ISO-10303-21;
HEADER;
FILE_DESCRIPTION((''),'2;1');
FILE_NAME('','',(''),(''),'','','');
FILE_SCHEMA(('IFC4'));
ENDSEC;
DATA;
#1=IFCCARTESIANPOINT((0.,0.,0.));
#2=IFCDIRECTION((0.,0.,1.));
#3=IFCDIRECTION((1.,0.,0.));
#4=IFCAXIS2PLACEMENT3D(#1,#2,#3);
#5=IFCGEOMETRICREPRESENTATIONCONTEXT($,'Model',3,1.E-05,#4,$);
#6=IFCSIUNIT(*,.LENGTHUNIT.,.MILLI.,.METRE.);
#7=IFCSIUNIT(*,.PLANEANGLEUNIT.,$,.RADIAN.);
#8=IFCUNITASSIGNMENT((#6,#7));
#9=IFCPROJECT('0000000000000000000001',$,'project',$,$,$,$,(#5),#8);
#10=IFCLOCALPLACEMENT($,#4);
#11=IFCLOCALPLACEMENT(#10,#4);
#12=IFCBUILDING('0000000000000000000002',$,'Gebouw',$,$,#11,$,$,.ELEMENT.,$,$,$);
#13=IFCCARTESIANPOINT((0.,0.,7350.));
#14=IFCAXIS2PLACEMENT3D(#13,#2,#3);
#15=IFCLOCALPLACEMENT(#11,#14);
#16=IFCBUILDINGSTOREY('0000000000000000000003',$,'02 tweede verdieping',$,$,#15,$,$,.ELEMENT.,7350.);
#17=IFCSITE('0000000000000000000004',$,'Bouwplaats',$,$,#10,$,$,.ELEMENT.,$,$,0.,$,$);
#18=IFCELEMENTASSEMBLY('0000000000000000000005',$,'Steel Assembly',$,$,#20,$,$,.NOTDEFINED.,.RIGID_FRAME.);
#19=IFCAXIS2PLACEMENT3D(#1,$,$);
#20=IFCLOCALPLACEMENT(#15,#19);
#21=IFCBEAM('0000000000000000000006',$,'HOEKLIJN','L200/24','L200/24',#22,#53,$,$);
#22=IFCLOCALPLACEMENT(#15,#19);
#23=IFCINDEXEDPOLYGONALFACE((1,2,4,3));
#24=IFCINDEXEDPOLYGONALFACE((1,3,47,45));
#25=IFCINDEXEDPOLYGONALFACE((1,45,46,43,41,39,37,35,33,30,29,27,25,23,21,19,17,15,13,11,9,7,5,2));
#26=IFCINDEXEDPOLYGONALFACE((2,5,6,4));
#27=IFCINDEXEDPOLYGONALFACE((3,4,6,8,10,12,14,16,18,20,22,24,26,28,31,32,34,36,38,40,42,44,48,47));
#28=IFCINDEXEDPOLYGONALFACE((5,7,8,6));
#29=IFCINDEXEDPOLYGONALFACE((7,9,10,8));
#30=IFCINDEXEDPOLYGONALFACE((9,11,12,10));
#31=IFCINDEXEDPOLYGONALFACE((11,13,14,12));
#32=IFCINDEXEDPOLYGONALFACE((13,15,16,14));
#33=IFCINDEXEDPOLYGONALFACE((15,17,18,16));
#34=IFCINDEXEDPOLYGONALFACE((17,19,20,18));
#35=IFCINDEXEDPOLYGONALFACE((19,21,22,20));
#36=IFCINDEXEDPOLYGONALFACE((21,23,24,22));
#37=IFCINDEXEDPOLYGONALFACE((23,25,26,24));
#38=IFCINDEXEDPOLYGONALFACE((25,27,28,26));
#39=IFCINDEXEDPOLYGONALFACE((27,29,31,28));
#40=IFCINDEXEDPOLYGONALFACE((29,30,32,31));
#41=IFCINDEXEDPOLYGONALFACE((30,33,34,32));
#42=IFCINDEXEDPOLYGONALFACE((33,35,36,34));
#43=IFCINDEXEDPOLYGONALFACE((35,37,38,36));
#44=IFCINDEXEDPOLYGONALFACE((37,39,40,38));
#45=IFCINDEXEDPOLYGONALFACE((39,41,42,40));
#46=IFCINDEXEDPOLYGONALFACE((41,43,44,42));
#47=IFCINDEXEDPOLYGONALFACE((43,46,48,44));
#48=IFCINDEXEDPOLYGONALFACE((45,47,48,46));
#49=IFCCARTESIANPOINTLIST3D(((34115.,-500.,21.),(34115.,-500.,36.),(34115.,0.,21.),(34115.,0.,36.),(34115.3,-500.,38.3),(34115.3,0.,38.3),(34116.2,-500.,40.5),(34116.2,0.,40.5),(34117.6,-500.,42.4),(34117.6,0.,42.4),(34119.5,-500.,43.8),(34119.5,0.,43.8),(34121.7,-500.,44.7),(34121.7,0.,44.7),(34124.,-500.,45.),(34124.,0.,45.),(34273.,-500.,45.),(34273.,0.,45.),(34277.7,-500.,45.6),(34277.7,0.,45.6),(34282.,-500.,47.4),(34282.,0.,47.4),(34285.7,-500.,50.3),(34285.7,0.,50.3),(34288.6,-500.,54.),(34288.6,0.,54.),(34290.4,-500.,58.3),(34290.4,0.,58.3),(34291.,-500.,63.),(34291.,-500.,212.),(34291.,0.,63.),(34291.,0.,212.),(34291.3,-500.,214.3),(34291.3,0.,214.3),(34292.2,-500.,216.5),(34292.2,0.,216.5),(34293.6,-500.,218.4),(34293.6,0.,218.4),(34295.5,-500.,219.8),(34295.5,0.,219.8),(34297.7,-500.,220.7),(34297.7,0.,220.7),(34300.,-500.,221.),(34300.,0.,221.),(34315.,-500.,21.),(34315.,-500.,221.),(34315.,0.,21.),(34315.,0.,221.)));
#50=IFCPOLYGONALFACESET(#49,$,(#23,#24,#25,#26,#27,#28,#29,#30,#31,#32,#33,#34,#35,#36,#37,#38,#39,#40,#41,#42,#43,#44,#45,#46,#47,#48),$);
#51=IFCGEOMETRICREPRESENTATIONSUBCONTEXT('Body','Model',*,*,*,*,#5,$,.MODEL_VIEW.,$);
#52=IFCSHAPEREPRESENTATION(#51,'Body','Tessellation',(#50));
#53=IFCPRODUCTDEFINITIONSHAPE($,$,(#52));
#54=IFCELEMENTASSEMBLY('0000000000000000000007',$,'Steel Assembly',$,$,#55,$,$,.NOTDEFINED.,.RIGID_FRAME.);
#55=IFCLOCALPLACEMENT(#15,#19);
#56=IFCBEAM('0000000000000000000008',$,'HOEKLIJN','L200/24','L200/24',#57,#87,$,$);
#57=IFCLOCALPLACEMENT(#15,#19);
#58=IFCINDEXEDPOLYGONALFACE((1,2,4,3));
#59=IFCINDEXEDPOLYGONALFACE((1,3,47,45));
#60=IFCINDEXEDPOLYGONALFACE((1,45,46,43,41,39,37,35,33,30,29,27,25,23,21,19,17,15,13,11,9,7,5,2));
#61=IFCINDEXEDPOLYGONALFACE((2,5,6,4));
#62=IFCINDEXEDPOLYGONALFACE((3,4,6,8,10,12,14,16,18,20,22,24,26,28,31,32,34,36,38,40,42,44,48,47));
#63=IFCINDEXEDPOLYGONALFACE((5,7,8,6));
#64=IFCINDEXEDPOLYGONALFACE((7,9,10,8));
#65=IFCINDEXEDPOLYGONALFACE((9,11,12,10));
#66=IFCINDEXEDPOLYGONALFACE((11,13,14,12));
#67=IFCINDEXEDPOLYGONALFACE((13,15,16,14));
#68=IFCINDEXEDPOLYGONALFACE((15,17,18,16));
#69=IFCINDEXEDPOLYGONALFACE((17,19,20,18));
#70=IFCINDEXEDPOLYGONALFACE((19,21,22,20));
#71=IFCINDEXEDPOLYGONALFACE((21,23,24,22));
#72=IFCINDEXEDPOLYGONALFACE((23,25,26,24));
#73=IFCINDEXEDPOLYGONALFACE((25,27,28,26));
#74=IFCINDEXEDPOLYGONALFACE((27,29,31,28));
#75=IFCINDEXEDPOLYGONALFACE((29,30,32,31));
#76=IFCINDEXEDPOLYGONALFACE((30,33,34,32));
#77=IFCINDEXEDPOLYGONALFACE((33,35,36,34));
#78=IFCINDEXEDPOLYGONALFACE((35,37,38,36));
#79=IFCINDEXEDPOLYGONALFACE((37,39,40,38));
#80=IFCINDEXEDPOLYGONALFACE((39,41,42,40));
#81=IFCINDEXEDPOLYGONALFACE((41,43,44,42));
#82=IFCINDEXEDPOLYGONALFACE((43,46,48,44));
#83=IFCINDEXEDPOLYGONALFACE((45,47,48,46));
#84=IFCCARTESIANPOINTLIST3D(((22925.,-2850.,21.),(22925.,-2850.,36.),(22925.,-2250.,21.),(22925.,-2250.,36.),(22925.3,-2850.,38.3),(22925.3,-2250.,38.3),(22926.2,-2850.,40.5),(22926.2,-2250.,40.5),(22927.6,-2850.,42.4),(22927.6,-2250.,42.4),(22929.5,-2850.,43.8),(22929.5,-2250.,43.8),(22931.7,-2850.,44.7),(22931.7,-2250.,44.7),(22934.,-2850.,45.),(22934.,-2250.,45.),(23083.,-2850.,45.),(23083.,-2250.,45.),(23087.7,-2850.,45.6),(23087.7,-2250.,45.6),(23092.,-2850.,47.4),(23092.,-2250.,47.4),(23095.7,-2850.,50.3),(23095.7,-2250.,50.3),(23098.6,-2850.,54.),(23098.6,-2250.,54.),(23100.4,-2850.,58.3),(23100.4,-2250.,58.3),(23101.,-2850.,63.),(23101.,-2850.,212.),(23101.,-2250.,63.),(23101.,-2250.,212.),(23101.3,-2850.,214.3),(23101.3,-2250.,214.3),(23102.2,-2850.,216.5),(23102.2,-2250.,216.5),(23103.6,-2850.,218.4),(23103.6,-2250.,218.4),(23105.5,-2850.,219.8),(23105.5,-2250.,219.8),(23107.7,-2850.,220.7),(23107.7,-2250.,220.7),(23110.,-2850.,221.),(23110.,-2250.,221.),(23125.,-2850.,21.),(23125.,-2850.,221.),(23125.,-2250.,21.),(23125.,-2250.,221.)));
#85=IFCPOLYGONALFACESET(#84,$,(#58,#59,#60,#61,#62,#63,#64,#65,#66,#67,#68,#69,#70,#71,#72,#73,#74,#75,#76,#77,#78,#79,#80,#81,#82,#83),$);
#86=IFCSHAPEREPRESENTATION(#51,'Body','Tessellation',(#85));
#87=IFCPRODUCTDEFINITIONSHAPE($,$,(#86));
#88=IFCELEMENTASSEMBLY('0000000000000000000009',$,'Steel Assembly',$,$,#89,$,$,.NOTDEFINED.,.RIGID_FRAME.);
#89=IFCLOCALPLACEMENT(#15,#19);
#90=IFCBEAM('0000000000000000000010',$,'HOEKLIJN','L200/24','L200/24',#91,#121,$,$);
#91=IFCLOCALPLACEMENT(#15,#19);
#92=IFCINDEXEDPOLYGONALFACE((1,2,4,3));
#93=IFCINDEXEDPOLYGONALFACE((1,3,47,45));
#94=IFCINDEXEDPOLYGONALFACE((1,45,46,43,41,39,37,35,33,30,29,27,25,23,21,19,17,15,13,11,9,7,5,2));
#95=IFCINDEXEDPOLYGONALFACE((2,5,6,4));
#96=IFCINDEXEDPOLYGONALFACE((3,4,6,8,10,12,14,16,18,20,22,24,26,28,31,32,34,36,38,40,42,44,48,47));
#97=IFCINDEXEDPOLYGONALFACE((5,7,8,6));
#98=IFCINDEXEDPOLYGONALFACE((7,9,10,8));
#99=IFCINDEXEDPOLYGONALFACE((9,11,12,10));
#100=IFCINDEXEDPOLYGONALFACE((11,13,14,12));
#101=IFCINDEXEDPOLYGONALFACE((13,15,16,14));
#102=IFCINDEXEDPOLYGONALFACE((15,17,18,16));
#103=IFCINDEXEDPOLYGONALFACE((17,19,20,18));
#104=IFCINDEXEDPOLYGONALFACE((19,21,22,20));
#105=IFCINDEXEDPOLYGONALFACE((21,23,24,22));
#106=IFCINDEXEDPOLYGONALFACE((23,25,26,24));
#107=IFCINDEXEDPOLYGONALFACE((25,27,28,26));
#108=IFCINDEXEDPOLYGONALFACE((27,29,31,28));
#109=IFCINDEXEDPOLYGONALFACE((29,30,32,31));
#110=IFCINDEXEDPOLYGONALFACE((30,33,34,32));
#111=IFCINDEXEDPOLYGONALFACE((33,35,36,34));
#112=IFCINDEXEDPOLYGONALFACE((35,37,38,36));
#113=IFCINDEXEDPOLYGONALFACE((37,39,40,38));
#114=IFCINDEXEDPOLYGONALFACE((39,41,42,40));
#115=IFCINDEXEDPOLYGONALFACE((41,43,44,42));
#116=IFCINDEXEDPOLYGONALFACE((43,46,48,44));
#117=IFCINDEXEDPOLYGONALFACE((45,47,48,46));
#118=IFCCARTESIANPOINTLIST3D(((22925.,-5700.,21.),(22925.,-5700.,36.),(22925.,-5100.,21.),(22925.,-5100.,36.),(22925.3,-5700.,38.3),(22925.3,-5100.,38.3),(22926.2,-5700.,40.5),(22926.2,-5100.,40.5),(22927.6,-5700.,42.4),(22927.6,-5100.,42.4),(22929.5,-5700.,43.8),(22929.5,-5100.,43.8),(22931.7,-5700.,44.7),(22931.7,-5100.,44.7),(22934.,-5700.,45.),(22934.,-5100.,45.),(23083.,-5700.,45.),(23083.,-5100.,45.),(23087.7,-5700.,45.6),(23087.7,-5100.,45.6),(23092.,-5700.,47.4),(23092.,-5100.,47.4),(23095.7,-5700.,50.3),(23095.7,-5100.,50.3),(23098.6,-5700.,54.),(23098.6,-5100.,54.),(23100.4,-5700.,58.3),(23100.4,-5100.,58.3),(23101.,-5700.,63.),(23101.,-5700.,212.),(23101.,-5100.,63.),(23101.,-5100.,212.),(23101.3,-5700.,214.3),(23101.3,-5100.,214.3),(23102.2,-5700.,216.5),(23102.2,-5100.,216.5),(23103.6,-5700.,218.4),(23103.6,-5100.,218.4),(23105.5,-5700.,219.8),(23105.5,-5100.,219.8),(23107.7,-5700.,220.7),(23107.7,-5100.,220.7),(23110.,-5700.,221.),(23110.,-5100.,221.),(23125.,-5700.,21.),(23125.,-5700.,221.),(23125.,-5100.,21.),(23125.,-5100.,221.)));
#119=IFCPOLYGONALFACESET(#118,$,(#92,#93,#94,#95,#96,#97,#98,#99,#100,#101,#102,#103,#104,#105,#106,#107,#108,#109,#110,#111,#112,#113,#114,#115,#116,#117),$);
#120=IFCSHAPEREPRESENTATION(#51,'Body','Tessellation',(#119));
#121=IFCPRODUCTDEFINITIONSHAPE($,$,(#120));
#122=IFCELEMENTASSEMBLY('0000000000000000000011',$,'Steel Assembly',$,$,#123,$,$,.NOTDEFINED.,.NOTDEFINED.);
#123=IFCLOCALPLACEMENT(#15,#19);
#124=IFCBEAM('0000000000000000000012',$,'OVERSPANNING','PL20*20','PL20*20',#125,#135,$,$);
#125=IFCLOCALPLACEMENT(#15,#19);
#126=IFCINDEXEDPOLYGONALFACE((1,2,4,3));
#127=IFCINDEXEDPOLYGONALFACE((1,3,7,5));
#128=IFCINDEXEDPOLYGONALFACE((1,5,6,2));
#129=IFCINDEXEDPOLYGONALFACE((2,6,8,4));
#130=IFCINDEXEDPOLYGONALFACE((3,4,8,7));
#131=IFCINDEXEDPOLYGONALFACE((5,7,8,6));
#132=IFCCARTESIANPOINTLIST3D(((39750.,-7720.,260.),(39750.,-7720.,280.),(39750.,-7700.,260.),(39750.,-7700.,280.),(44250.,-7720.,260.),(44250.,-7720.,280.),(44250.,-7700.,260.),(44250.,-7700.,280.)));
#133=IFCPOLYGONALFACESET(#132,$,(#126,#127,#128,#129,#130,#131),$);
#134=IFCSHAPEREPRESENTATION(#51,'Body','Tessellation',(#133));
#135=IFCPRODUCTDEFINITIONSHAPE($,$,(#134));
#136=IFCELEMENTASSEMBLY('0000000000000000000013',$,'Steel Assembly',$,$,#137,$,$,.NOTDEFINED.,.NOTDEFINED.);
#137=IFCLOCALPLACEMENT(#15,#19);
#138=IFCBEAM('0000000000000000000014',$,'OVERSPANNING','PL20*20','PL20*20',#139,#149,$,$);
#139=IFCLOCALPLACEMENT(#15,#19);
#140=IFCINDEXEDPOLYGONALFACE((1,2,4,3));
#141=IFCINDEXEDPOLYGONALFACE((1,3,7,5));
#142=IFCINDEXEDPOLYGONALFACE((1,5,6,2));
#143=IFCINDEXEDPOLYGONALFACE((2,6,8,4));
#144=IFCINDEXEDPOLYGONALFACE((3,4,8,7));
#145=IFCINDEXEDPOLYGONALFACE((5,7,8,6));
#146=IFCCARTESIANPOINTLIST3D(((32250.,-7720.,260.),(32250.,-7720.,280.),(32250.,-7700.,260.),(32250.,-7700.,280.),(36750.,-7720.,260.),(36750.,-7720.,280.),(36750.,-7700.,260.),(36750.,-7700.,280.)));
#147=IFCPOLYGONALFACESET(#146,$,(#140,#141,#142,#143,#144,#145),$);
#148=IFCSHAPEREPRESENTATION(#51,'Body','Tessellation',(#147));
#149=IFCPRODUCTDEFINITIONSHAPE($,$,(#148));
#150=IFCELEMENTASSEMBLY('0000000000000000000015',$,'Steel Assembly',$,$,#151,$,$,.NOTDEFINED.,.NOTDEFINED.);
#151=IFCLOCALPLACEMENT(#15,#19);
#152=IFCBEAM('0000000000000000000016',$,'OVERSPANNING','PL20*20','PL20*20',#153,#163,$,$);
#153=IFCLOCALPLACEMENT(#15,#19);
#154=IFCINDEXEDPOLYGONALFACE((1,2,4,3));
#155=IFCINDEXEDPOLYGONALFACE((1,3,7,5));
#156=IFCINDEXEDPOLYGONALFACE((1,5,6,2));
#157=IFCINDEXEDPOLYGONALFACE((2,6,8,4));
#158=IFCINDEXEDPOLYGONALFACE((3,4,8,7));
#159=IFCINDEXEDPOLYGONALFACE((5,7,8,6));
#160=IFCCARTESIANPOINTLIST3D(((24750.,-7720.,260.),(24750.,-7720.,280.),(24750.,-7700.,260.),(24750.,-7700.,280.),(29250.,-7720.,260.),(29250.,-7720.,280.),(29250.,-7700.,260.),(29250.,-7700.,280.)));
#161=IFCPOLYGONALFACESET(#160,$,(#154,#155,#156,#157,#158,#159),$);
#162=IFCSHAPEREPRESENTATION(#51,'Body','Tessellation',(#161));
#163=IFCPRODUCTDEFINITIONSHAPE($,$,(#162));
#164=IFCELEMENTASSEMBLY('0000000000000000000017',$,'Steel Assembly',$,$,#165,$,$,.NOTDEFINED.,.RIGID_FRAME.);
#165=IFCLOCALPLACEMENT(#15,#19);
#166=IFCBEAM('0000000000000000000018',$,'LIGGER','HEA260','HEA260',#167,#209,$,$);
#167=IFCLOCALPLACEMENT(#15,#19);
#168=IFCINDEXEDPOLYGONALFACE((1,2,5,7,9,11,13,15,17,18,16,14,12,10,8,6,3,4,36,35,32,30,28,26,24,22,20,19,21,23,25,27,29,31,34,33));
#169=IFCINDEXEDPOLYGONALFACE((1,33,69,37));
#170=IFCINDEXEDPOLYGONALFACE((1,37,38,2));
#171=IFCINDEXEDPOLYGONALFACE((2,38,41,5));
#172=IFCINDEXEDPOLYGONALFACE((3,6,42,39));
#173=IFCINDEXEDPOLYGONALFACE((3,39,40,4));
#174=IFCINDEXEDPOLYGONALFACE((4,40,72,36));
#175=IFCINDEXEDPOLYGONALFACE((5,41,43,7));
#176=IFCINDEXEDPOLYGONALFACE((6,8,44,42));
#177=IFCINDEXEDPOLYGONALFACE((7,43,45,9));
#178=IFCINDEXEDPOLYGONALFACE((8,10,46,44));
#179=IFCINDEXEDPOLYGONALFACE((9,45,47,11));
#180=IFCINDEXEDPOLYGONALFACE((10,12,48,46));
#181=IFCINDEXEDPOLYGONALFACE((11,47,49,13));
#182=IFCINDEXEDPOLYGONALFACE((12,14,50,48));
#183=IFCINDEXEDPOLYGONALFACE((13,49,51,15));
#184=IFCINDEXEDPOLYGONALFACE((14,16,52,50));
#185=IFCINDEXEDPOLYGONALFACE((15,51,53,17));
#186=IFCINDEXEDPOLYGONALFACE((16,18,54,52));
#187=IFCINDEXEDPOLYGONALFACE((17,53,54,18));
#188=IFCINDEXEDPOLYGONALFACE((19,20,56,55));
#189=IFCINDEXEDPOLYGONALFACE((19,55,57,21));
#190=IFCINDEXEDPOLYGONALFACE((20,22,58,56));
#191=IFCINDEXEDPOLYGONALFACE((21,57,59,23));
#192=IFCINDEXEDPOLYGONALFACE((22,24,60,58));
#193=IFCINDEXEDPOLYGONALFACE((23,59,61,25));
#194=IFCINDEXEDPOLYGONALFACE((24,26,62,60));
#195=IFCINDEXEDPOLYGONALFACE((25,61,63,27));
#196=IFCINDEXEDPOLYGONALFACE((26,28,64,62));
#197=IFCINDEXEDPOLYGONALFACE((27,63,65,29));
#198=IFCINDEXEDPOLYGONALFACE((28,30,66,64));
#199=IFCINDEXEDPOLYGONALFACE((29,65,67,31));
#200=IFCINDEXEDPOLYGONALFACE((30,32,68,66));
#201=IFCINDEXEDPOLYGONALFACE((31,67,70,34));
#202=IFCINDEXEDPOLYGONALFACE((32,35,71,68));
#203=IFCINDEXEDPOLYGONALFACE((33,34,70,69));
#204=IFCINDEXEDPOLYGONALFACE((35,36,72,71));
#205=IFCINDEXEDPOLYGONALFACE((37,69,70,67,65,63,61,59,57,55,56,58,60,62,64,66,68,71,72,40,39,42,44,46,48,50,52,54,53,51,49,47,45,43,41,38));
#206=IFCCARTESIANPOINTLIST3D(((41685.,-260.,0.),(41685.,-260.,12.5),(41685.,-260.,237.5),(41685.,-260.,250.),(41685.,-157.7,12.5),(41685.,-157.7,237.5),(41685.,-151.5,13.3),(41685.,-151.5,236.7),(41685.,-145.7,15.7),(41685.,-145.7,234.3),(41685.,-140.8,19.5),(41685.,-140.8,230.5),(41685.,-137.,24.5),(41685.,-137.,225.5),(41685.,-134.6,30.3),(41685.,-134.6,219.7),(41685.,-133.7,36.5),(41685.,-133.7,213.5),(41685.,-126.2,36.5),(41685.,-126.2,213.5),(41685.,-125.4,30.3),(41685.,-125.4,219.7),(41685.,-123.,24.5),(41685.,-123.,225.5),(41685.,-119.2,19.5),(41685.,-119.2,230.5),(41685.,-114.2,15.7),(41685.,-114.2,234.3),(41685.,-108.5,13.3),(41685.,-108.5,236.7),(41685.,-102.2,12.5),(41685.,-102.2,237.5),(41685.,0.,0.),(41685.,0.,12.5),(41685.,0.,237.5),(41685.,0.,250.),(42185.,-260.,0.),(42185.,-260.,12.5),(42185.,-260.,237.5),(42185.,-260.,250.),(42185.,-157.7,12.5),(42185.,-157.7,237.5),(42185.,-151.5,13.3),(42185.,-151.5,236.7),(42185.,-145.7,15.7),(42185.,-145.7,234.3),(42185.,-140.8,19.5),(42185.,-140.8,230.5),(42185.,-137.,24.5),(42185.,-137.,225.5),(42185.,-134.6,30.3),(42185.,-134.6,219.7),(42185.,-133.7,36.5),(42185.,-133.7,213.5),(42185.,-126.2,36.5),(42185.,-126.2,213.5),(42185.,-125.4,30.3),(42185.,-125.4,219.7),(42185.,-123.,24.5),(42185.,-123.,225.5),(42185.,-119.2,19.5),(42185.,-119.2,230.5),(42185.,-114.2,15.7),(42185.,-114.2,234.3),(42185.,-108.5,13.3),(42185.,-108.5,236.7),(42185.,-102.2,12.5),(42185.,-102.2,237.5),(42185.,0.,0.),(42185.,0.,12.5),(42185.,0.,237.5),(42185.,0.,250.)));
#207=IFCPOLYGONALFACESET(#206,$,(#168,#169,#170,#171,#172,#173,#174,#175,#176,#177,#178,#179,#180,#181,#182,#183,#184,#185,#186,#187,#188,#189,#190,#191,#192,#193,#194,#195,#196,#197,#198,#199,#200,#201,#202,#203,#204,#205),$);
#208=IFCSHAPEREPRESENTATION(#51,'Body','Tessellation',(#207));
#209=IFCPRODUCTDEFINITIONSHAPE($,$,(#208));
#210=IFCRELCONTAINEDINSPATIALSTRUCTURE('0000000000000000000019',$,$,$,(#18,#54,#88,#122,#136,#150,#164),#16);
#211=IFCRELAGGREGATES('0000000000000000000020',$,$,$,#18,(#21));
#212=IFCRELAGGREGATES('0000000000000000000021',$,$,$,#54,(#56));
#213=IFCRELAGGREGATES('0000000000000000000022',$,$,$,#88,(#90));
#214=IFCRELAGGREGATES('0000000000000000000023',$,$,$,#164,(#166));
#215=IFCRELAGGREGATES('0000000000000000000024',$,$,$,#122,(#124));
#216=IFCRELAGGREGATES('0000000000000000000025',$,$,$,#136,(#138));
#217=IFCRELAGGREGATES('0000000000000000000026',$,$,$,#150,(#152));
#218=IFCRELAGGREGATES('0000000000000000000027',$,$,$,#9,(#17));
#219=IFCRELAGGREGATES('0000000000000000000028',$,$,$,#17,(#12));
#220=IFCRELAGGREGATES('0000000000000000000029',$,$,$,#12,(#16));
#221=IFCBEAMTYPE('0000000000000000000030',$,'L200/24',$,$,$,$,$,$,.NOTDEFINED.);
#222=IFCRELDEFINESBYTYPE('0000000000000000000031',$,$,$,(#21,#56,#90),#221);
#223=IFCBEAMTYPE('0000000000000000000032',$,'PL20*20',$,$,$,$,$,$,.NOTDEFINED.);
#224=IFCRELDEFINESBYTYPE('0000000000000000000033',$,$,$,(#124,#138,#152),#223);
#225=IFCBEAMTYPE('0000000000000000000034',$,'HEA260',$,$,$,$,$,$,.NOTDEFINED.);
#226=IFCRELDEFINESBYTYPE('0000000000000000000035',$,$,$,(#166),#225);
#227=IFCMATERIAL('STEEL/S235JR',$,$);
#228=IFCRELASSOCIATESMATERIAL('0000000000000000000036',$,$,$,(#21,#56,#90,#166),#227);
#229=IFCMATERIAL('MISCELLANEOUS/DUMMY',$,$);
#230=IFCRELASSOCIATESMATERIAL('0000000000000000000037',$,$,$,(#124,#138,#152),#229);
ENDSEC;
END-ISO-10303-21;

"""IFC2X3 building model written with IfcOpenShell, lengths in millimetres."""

from ifc_helpers import new_model, si_unit, frame, origin_with_axes, origin_2d_with_axis, place, context, subcontext, project, spatial, rectangle, i_section, l_section, extrude, material, type_object, element, aggregate, save


model = new_model("IFC2X3")

# Units and contexts
model_context = context("Model", 3, precision=1e-05, world=origin_with_axes())
body_context = subcontext(model_context, "Body", "Model", "MODEL_VIEW")
ifc_project = project(units=[si_unit("LENGTHUNIT", "METRE", prefix="MILLI"), si_unit("PLANEANGLEUNIT", "RADIAN")], contexts=[model_context])

# Site, building, storey
site_placement = place(None, origin_with_axes())
site = spatial("IfcSite", under=ifc_project, at=site_placement, Name="Bouwplaats", CompositionType="ELEMENT", RefElevation=0.0)
building_placement = place(site_placement, origin_with_axes())
building = spatial("IfcBuilding", under=site, at=building_placement, Name="Gebouw", CompositionType="ELEMENT")
storey_placement = place(building_placement, frame((0.0, 0.0, 7350.0), z_axis=(0.0, 0.0, 1.0), x_axis=(1.0, 0.0, 0.0)))
storey = spatial("IfcBuildingStorey", under=building, at=storey_placement, Name="02 tweede verdieping", CompositionType="ELEMENT", Elevation=7350.0)

# Shared definitions
ifc_material_1 = material(Name="STEEL/S235JR")

# Element assemblies, beams
ifc_material_2 = material(Name="MISCELLANEOUS/DUMMY")
beam_type_1 = type_object("IfcBeamType", Name="L200/24", PredefinedType="NOTDEFINED")
assembly_1_placement = place(storey_placement, origin_with_axes())
assembly_1 = element("IfcElementAssembly", 1, at=assembly_1_placement, inside=storey, Name="Steel Assembly", AssemblyPlace="NOTDEFINED", PredefinedType="RIGID_FRAME")
beam_1_placement = place(assembly_1_placement, frame((34215.0, -500.0, 121.0), z_axis=(-1.0, 0.0, 0.0), x_axis=(0.0, 1.0, 0.0)))
beam_1 = element("IfcBeam", 2, at=beam_1_placement, type_object=beam_type_1, material=ifc_material_1, Name="HOEKLIJN", Description="L200/24", ObjectType="L200/24", context=body_context, shape_type="SweptSolid", body=[
    extrude(l_section(Depth=200.0, Width=200.0, Thickness=24.0, FilletRadius=18.0, EdgeRadius=9.0, at=origin_2d_with_axis()), frame((500.0, 0.0, 0.0), z_axis=(-1.0, 0.0, 0.0), x_axis=(0.0, -1.0, 0.0)), (0.0, 0.0, 1.0), 500.0),
])
aggregate(assembly_1, [beam_1])
assembly_2_placement = place(storey_placement, origin_with_axes())
assembly_2 = element("IfcElementAssembly", 3, at=assembly_2_placement, inside=storey, Name="Steel Assembly", AssemblyPlace="NOTDEFINED", PredefinedType="RIGID_FRAME")
beam_2_placement = place(assembly_2_placement, frame((23025.0, -2850.0, 121.0), z_axis=(-1.0, 0.0, 0.0), x_axis=(0.0, 1.0, 0.0)))
beam_2 = element("IfcBeam", 4, at=beam_2_placement, type_object=beam_type_1, material=ifc_material_1, Name="HOEKLIJN", Description="L200/24", ObjectType="L200/24", context=body_context, shape_type="SweptSolid", body=[
    extrude(l_section(Depth=200.0, Width=200.0, Thickness=24.0, FilletRadius=18.0, EdgeRadius=9.0, at=origin_2d_with_axis()), frame((600.0, 0.0, 0.0), z_axis=(-1.0, 0.0, 0.0), x_axis=(0.0, -1.0, 0.0)), (0.0, 0.0, 1.0), 600.0),
])
aggregate(assembly_2, [beam_2])
assembly_3_placement = place(storey_placement, origin_with_axes())
assembly_3 = element("IfcElementAssembly", 5, at=assembly_3_placement, inside=storey, Name="Steel Assembly", AssemblyPlace="NOTDEFINED", PredefinedType="RIGID_FRAME")
beam_3_placement = place(assembly_3_placement, frame((23025.0, -5700.0, 121.0), z_axis=(-1.0, 0.0, 0.0), x_axis=(0.0, 1.0, 0.0)))
beam_3 = element("IfcBeam", 6, at=beam_3_placement, type_object=beam_type_1, material=ifc_material_1, Name="HOEKLIJN", Description="L200/24", ObjectType="L200/24", context=body_context, shape_type="SweptSolid", body=[
    extrude(l_section(Depth=200.0, Width=200.0, Thickness=24.0, FilletRadius=18.0, EdgeRadius=9.0, at=origin_2d_with_axis()), frame((600.0, 0.0, 0.0), z_axis=(-1.0, 0.0, 0.0), x_axis=(0.0, -1.0, 0.0)), (0.0, 0.0, 1.0), 600.0),
])
aggregate(assembly_3, [beam_3])
assembly_4_placement = place(storey_placement, origin_with_axes())
assembly_4 = element("IfcElementAssembly", 7, at=assembly_4_placement, inside=storey, Name="Steel Assembly", AssemblyPlace="NOTDEFINED", PredefinedType="NOTDEFINED")
beam_type_2 = type_object("IfcBeamType", Name="PL20*20", PredefinedType="NOTDEFINED")
beam_4_placement = place(assembly_4_placement, frame((39750.0, -7710.0, 270.0), z_axis=(0.0, 1.0, 0.0), x_axis=(1.0, 0.0, 0.0)))
beam_4 = element("IfcBeam", 8, at=beam_4_placement, type_object=beam_type_2, material=ifc_material_2, Name="OVERSPANNING", Description="PL20*20", ObjectType="PL20*20", context=body_context, shape_type="SweptSolid", body=[
    extrude(rectangle(XDim=20.0, YDim=20.0, at=origin_2d_with_axis()), frame((4500.0, 0.0, 0.0), z_axis=(-1.0, 0.0, 0.0), x_axis=(0.0, -1.0, 0.0)), (0.0, 0.0, 1.0), 4500.0),
])
assembly_5_placement = place(storey_placement, origin_with_axes())
assembly_5 = element("IfcElementAssembly", 9, at=assembly_5_placement, inside=storey, Name="Steel Assembly", AssemblyPlace="NOTDEFINED", PredefinedType="NOTDEFINED")
beam_5_placement = place(assembly_5_placement, frame((32250.0, -7710.0, 270.0), z_axis=(0.0, 1.0, 0.0), x_axis=(1.0, 0.0, 0.0)))
beam_5 = element("IfcBeam", 10, at=beam_5_placement, type_object=beam_type_2, material=ifc_material_2, Name="OVERSPANNING", Description="PL20*20", ObjectType="PL20*20", context=body_context, shape_type="SweptSolid", body=[
    extrude(rectangle(XDim=20.0, YDim=20.0, at=origin_2d_with_axis()), frame((4500.0, 0.0, 0.0), z_axis=(-1.0, 0.0, 0.0), x_axis=(0.0, -1.0, 0.0)), (0.0, 0.0, 1.0), 4500.0),
])
assembly_6_placement = place(storey_placement, origin_with_axes())
assembly_6 = element("IfcElementAssembly", 11, at=assembly_6_placement, inside=storey, Name="Steel Assembly", AssemblyPlace="NOTDEFINED", PredefinedType="NOTDEFINED")
beam_6_placement = place(assembly_6_placement, frame((24750.0, -7710.0, 270.0), z_axis=(0.0, 1.0, 0.0), x_axis=(1.0, 0.0, 0.0)))
beam_6 = element("IfcBeam", 12, at=beam_6_placement, type_object=beam_type_2, material=ifc_material_2, Name="OVERSPANNING", Description="PL20*20", ObjectType="PL20*20", context=body_context, shape_type="SweptSolid", body=[
    extrude(rectangle(XDim=20.0, YDim=20.0, at=origin_2d_with_axis()), frame((4500.0, 0.0, 0.0), z_axis=(-1.0, 0.0, 0.0), x_axis=(0.0, -1.0, 0.0)), (0.0, 0.0, 1.0), 4500.0),
])
assembly_7_placement = place(storey_placement, origin_with_axes())
assembly_7 = element("IfcElementAssembly", 13, at=assembly_7_placement, inside=storey, Name="Steel Assembly", AssemblyPlace="NOTDEFINED", PredefinedType="RIGID_FRAME")
beam_type_3 = type_object("IfcBeamType", Name="HEA260", PredefinedType="NOTDEFINED")
beam_7_placement = place(assembly_7_placement, frame((42185.0, -130.0, 125.0), z_axis=(0.0, 0.0, 1.0), x_axis=(-1.0, 0.0, 0.0)))
beam_7 = element("IfcBeam", 14, at=beam_7_placement, type_object=beam_type_3, material=ifc_material_1, Name="LIGGER", Description="HEA260", ObjectType="HEA260", context=body_context, shape_type="SweptSolid", body=[
    extrude(i_section(OverallWidth=260.0, OverallDepth=250.0, WebThickness=7.5, FlangeThickness=12.5, FilletRadius=24.0, at=origin_2d_with_axis()), frame((500.0, 0.0, 0.0), z_axis=(-1.0, 0.0, 0.0), x_axis=(0.0, -1.0, 0.0)), (0.0, 0.0, 1.0), 500.0),
])
aggregate(assembly_7, [beam_7])

aggregate(assembly_4, [beam_4])
aggregate(assembly_5, [beam_5])
aggregate(assembly_6, [beam_6])

save(model, "model.ifc")
